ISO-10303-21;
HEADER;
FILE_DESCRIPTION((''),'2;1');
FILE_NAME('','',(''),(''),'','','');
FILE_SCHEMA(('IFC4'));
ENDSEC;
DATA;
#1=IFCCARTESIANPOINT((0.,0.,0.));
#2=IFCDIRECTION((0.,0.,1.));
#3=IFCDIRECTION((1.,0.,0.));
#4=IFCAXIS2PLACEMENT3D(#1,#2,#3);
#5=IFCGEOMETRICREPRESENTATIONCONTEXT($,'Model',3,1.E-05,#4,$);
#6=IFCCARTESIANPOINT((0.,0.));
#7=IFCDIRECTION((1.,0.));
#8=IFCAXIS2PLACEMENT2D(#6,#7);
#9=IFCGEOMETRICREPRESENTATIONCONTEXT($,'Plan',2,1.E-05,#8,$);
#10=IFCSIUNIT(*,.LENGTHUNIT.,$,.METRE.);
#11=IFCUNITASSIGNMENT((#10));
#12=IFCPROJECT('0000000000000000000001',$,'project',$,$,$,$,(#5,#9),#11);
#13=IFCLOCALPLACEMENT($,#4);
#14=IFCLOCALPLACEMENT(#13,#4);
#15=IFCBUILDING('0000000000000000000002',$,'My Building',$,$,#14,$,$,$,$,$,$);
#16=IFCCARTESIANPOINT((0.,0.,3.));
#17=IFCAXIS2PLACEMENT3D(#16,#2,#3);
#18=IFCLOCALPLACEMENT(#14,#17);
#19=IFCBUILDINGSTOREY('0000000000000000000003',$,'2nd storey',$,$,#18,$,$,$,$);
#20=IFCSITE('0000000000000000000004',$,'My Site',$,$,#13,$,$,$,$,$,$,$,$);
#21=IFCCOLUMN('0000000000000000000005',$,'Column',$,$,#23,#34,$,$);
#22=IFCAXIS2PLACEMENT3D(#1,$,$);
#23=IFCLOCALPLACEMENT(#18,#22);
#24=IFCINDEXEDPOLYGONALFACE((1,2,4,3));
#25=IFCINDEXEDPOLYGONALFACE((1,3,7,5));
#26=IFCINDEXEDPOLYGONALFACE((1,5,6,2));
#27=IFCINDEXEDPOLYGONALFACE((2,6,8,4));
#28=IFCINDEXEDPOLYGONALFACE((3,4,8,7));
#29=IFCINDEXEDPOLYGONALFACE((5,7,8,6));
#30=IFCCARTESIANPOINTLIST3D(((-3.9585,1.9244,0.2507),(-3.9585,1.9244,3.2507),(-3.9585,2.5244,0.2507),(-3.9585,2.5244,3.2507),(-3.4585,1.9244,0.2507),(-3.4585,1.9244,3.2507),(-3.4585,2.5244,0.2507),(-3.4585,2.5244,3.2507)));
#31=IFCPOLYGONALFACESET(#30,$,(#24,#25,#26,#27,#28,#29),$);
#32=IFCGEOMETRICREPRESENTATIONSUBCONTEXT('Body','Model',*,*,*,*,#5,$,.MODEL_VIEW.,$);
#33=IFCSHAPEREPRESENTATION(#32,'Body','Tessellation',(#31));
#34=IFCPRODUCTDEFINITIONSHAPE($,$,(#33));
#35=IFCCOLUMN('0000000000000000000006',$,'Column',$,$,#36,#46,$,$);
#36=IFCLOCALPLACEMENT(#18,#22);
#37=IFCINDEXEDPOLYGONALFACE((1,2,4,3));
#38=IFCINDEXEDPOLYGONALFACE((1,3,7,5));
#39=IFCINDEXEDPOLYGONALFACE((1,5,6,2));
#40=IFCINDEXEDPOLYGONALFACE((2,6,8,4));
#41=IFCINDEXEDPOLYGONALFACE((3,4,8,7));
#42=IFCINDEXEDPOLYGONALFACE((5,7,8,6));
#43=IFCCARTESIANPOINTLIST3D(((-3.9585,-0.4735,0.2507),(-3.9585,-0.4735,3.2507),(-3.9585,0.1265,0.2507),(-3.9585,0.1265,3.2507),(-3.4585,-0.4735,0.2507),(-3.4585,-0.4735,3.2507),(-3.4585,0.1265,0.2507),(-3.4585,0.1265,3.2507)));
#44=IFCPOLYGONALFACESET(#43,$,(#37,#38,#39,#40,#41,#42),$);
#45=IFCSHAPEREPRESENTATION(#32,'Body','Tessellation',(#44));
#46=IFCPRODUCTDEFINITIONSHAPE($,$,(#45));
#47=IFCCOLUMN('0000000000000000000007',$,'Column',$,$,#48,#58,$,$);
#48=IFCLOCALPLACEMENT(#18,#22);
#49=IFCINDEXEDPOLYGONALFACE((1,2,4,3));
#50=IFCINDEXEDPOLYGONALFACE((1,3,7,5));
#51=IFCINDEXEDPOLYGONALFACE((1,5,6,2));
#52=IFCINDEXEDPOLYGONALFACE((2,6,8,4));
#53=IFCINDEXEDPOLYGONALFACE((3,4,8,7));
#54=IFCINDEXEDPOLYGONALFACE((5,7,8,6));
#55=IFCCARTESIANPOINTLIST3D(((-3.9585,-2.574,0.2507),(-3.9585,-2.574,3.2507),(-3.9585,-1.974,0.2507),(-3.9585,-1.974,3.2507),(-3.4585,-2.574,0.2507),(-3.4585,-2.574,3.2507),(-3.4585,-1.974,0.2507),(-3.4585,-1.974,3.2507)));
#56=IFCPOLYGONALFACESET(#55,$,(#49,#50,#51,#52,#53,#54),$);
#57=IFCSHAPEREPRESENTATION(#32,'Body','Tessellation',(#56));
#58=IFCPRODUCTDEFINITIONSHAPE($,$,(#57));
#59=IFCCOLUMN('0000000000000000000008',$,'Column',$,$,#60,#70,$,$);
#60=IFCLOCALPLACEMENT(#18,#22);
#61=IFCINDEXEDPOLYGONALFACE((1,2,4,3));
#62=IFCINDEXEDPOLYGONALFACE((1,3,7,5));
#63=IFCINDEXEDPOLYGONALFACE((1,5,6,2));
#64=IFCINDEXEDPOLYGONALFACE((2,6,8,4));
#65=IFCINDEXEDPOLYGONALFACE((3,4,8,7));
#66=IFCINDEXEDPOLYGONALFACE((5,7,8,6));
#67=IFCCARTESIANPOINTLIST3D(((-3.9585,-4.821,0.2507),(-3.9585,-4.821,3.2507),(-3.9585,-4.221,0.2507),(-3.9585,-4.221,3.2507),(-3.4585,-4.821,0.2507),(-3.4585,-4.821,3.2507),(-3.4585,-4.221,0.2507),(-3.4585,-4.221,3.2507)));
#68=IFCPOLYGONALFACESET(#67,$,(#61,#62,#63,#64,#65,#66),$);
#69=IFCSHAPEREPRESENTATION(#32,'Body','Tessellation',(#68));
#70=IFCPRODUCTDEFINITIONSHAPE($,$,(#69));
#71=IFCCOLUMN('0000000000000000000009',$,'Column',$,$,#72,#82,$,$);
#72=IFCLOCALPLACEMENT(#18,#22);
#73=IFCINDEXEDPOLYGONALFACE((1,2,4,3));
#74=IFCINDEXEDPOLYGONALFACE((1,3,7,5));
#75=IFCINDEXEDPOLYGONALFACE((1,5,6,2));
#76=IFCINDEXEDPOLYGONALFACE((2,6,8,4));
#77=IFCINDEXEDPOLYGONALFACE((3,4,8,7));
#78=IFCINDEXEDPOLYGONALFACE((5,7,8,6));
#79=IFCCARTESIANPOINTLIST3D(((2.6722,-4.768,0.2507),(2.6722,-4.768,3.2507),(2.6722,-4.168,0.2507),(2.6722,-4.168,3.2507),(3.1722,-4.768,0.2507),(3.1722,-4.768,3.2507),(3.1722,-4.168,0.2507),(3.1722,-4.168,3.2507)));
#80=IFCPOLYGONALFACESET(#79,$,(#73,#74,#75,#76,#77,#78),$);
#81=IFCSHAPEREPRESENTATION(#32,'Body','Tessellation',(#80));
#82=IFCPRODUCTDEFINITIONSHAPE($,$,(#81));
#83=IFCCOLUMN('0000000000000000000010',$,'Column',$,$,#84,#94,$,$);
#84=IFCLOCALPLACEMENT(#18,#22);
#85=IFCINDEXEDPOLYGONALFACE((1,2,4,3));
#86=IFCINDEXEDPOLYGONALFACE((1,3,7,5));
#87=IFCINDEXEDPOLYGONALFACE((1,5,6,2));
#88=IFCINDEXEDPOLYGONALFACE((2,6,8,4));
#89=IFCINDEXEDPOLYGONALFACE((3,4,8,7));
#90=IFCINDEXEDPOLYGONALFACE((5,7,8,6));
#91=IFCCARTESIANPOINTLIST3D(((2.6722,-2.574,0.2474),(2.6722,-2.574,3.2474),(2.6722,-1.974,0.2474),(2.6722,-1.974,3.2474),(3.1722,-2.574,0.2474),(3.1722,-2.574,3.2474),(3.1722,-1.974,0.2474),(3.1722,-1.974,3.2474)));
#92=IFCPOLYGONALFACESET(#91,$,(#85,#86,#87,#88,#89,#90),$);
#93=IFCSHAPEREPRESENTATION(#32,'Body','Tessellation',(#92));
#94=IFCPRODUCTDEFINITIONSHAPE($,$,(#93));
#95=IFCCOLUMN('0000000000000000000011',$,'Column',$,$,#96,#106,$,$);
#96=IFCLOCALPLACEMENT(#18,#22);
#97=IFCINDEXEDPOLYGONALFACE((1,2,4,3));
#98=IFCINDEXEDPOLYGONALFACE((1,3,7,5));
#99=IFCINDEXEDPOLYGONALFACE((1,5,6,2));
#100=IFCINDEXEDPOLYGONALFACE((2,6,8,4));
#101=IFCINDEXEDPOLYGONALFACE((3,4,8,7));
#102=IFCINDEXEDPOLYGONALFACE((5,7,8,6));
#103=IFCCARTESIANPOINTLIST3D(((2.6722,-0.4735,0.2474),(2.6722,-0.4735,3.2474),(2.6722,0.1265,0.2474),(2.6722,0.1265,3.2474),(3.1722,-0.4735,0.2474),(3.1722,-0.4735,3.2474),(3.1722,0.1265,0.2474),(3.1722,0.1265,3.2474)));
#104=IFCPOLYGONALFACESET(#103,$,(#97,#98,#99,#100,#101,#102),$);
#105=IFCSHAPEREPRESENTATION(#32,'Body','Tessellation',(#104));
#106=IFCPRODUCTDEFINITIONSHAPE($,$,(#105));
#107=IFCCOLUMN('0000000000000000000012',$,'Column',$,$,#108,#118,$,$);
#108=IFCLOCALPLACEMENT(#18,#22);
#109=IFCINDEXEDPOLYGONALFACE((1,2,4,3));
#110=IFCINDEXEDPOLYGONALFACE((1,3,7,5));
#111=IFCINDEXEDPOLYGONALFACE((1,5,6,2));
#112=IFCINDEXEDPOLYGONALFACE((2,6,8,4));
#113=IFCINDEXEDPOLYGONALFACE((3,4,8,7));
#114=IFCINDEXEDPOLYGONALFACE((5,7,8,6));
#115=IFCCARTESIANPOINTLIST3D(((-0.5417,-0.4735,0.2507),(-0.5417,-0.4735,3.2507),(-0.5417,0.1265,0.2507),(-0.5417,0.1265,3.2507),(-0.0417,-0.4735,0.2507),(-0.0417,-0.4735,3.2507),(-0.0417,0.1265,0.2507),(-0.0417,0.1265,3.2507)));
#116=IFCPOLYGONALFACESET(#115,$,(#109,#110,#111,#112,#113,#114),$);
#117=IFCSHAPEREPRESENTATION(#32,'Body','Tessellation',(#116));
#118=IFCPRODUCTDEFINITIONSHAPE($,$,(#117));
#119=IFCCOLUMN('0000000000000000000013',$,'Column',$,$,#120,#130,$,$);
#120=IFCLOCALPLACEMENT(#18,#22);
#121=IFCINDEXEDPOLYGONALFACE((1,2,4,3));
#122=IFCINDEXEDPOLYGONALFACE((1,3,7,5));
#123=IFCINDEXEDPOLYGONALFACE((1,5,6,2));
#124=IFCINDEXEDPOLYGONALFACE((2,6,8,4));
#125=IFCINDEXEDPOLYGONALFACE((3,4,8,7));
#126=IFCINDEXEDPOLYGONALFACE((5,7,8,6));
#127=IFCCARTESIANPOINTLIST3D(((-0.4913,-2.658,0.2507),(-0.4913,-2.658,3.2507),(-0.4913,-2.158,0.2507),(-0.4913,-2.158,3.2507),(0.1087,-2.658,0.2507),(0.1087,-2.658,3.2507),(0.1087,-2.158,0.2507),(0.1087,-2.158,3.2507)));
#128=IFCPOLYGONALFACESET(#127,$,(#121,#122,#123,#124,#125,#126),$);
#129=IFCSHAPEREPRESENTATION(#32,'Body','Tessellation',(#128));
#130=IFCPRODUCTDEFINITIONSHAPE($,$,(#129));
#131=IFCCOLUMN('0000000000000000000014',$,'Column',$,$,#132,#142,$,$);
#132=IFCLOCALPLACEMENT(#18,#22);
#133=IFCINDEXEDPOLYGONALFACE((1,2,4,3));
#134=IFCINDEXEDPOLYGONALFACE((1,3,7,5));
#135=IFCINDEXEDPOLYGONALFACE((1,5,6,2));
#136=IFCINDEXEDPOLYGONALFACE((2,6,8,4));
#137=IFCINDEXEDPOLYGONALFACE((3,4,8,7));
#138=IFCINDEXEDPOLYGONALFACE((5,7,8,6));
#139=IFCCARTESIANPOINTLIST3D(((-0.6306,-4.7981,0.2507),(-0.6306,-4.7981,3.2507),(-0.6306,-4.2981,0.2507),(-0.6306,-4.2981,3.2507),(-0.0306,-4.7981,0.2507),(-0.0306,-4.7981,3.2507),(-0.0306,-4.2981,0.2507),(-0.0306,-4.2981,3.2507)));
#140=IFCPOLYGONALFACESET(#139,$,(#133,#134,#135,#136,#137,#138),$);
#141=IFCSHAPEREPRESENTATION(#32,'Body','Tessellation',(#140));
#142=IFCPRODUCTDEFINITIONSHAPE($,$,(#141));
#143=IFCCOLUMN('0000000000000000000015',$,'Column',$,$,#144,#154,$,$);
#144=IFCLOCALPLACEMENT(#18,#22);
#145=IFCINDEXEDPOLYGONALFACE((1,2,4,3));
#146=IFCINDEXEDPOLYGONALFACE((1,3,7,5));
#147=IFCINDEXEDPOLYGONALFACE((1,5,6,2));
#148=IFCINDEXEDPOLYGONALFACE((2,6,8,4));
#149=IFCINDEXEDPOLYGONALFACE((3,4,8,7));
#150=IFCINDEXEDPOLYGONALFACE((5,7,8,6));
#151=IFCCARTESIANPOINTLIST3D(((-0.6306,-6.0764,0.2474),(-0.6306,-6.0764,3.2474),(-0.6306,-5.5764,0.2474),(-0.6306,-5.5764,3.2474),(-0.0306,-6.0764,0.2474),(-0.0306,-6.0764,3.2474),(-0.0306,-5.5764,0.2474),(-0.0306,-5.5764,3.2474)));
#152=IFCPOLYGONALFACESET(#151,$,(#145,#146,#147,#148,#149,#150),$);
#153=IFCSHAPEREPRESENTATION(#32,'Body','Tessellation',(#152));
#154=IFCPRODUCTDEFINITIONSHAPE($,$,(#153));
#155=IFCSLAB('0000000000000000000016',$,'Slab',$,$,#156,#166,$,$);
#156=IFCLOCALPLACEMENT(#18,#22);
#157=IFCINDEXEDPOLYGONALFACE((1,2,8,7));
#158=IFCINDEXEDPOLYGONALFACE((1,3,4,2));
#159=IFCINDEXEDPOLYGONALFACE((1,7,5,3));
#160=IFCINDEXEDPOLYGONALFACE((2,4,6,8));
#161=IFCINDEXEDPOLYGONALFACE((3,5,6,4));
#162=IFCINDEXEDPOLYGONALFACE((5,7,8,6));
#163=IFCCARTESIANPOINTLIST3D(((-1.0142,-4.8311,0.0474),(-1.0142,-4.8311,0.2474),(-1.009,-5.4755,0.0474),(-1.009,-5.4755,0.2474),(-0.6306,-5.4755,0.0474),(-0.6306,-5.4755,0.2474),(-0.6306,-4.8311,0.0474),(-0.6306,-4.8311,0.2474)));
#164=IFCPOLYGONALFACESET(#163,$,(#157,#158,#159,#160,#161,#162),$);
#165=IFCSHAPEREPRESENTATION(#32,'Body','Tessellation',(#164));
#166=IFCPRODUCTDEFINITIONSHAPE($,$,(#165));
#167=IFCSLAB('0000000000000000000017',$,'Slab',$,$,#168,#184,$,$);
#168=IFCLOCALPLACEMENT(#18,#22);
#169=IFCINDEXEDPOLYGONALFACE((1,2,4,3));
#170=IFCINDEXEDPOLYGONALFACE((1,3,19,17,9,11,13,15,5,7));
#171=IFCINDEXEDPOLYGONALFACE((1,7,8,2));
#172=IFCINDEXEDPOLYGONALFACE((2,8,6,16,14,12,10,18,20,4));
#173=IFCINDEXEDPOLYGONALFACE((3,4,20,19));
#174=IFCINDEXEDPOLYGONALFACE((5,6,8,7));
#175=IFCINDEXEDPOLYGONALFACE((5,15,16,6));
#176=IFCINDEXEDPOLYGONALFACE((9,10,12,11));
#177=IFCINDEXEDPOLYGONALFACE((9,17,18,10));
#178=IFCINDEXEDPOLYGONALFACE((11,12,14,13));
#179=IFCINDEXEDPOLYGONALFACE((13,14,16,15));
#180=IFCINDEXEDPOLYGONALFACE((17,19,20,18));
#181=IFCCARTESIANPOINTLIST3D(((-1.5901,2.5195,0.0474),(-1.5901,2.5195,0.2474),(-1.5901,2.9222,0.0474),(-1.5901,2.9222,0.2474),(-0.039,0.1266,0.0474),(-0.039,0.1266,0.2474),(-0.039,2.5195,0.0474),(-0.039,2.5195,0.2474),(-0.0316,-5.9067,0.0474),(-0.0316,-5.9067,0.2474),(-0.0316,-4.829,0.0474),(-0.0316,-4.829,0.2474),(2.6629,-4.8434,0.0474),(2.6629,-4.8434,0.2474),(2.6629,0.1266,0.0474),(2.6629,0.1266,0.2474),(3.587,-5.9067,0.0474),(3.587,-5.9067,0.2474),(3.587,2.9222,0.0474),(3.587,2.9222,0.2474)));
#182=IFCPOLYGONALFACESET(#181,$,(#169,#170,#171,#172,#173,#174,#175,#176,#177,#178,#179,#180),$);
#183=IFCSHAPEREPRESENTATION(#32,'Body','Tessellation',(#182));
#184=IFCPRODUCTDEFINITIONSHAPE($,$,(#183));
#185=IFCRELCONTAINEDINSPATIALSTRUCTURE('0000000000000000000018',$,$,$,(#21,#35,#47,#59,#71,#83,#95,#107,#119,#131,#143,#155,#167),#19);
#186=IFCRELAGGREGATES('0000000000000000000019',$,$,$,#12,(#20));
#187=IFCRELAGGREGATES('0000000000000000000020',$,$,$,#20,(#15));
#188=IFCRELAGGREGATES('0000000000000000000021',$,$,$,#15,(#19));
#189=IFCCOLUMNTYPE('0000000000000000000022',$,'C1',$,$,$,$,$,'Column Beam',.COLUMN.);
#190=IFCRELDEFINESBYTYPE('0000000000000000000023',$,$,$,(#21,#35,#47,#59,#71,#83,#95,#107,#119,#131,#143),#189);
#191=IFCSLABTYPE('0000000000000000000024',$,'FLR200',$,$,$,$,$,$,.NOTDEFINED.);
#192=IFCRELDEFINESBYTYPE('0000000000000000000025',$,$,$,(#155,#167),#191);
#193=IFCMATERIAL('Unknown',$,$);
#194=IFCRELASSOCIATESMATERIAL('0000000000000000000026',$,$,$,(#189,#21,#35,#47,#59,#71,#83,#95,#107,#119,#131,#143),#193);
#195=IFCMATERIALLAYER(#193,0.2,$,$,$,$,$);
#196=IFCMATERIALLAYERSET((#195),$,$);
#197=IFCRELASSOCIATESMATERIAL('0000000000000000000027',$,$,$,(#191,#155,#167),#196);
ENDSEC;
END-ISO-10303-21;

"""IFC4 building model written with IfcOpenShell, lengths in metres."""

from ifc_helpers import new_model, si_unit, frame, origin_with_axes, origin_2d_with_axis, place, context, subcontext, project, spatial, indexed_curve, outline, extrude, material, layer, layer_set, layer_usage, material_profile, profile_set, profile_usage, type_object, element, save


model = new_model("IFC4")

# Units and contexts
model_context = context("Model", 3, precision=1e-05, world=origin_with_axes())
plan_context = context("Plan", 2, precision=1e-05, world=origin_2d_with_axis())
body_context = subcontext(model_context, "Body", "Model", "MODEL_VIEW")
ifc_project = project(units=[si_unit("LENGTHUNIT", "METRE")], contexts=[model_context, plan_context])

# Site, building, storey
site_placement = place(None, origin_with_axes())
site = spatial("IfcSite", under=ifc_project, at=site_placement, Name="My Site")
building_placement = place(site_placement, origin_with_axes())
building = spatial("IfcBuilding", under=site, at=building_placement, Name="My Building")
storey_placement = place(building_placement, frame((0.0, 0.0, 3.0), z_axis=(0.0, 0.0, 1.0), x_axis=(1.0, 0.0, 0.0)))
storey = spatial("IfcBuildingStorey", under=building, at=storey_placement, Name="2nd storey")

# Columns
ifc_material = material(Name="Unknown")
ifc_material_profile = material_profile(ifc_material, outline(indexed_curve([(-0.25, -0.3), (0.25, -0.3), (0.25, 0.3), (-0.25, 0.3), (-0.25, -0.3)])))
ifc_profile_set = profile_set([ifc_material_profile])
ifc_profile_usage_1 = profile_usage(ifc_profile_set, cardinal=5)
column_type = type_object("IfcColumnType", Name="C1", ElementType="Column Beam", PredefinedType="COLUMN", material=ifc_profile_set)
column_1_placement = place(storey_placement, frame((-3.7085, 2.2244, 0.2507), z_axis=(0.0, 0.0, 1.0), x_axis=(1.0, 0.0, 0.0)))
element("IfcColumn", 1, at=column_1_placement, inside=storey, type_object=column_type, material=ifc_profile_usage_1, Name="Column", context=body_context, shape_type="SweptSolid", body=[
    extrude(outline(indexed_curve([(-0.25, -0.3), (0.25, -0.3), (0.25, 0.3), (-0.25, 0.3), (-0.25, -0.3)])), origin_with_axes(), (0.0, 0.0, 1.0), 3.0),
])
ifc_profile_usage_2 = profile_usage(ifc_profile_set, cardinal=5)
column_2_placement = place(storey_placement, frame((-3.7085, -0.1735, 0.2507), z_axis=(0.0, 0.0, 1.0), x_axis=(1.0, 0.0, 0.0)))
element("IfcColumn", 2, at=column_2_placement, inside=storey, type_object=column_type, material=ifc_profile_usage_2, Name="Column", context=body_context, shape_type="SweptSolid", body=[
    extrude(outline(indexed_curve([(-0.25, -0.3), (0.25, -0.3), (0.25, 0.3), (-0.25, 0.3), (-0.25, -0.3)])), origin_with_axes(), (0.0, 0.0, 1.0), 3.0),
])
ifc_profile_usage_3 = profile_usage(ifc_profile_set, cardinal=5)
column_3_placement = place(storey_placement, frame((-3.7085, -2.274, 0.2507), z_axis=(0.0, 0.0, 1.0), x_axis=(1.0, 0.0, 0.0)))
element("IfcColumn", 3, at=column_3_placement, inside=storey, type_object=column_type, material=ifc_profile_usage_3, Name="Column", context=body_context, shape_type="SweptSolid", body=[
    extrude(outline(indexed_curve([(-0.25, -0.3), (0.25, -0.3), (0.25, 0.3), (-0.25, 0.3), (-0.25, -0.3)])), origin_with_axes(), (0.0, 0.0, 1.0), 3.0),
])
ifc_profile_usage_4 = profile_usage(ifc_profile_set, cardinal=5)
column_4_placement = place(storey_placement, frame((-3.7085, -4.521, 0.2507), z_axis=(0.0, 0.0, 1.0), x_axis=(1.0, 0.0, 0.0)))
element("IfcColumn", 4, at=column_4_placement, inside=storey, type_object=column_type, material=ifc_profile_usage_4, Name="Column", context=body_context, shape_type="SweptSolid", body=[
    extrude(outline(indexed_curve([(-0.25, -0.3), (0.25, -0.3), (0.25, 0.3), (-0.25, 0.3), (-0.25, -0.3)])), origin_with_axes(), (0.0, 0.0, 1.0), 3.0),
])
ifc_profile_usage_5 = profile_usage(ifc_profile_set, cardinal=5)
column_5_placement = place(storey_placement, frame((2.9222, -4.468, 0.2507), z_axis=(0.0, 0.0, 1.0), x_axis=(1.0, 0.0, 0.0)))
element("IfcColumn", 5, at=column_5_placement, inside=storey, type_object=column_type, material=ifc_profile_usage_5, Name="Column", context=body_context, shape_type="SweptSolid", body=[
    extrude(outline(indexed_curve([(-0.25, -0.3), (0.25, -0.3), (0.25, 0.3), (-0.25, 0.3), (-0.25, -0.3)])), origin_with_axes(), (0.0, 0.0, 1.0), 3.0),
])
ifc_profile_usage_6 = profile_usage(ifc_profile_set, cardinal=5)
column_6_placement = place(storey_placement, frame((2.9222, -2.274, 0.2474), z_axis=(0.0, 0.0, 1.0), x_axis=(1.0, 0.0, 0.0)))
element("IfcColumn", 6, at=column_6_placement, inside=storey, type_object=column_type, material=ifc_profile_usage_6, Name="Column", context=body_context, shape_type="SweptSolid", body=[
    extrude(outline(indexed_curve([(-0.25, -0.3), (0.25, -0.3), (0.25, 0.3), (-0.25, 0.3), (-0.25, -0.3)])), origin_with_axes(), (0.0, 0.0, 1.0), 3.0),
])
ifc_profile_usage_7 = profile_usage(ifc_profile_set, cardinal=5)
column_7_placement = place(storey_placement, frame((2.9222, -0.1735, 0.2474), z_axis=(0.0, 0.0, 1.0), x_axis=(1.0, 0.0, 0.0)))
element("IfcColumn", 7, at=column_7_placement, inside=storey, type_object=column_type, material=ifc_profile_usage_7, Name="Column", context=body_context, shape_type="SweptSolid", body=[
    extrude(outline(indexed_curve([(-0.25, -0.3), (0.25, -0.3), (0.25, 0.3), (-0.25, 0.3), (-0.25, -0.3)])), origin_with_axes(), (0.0, 0.0, 1.0), 3.0),
])
ifc_profile_usage_8 = profile_usage(ifc_profile_set, cardinal=5)
column_8_placement = place(storey_placement, frame((-0.2917, -0.1735, 0.2507), z_axis=(0.0, 0.0, 1.0), x_axis=(1.0, 0.0, 0.0)))
element("IfcColumn", 8, at=column_8_placement, inside=storey, type_object=column_type, material=ifc_profile_usage_8, Name="Column", context=body_context, shape_type="SweptSolid", body=[
    extrude(outline(indexed_curve([(-0.25, -0.3), (0.25, -0.3), (0.25, 0.3), (-0.25, 0.3), (-0.25, -0.3)])), origin_with_axes(), (0.0, 0.0, 1.0), 3.0),
])
ifc_profile_usage_9 = profile_usage(ifc_profile_set, cardinal=5)
column_9_placement = place(storey_placement, frame((-0.1913, -2.408, 0.2507), z_axis=(0.0, 0.0, 1.0), x_axis=(0.0, -1.0, 0.0)))
element("IfcColumn", 9, at=column_9_placement, inside=storey, type_object=column_type, material=ifc_profile_usage_9, Name="Column", context=body_context, shape_type="SweptSolid", body=[
    extrude(outline(indexed_curve([(-0.25, -0.3), (0.25, -0.3), (0.25, 0.3), (-0.25, 0.3), (-0.25, -0.3)])), origin_with_axes(), (0.0, 0.0, 1.0), 3.0),
])
ifc_profile_usage_10 = profile_usage(ifc_profile_set, cardinal=5)
column_10_placement = place(storey_placement, frame((-0.3306, -4.5481, 0.2507), z_axis=(0.0, 0.0, 1.0), x_axis=(0.0, -1.0, 0.0)))
element("IfcColumn", 10, at=column_10_placement, inside=storey, type_object=column_type, material=ifc_profile_usage_10, Name="Column", context=body_context, shape_type="SweptSolid", body=[
    extrude(outline(indexed_curve([(-0.25, -0.3), (0.25, -0.3), (0.25, 0.3), (-0.25, 0.3), (-0.25, -0.3)])), origin_with_axes(), (0.0, 0.0, 1.0), 3.0),
])
ifc_profile_usage_11 = profile_usage(ifc_profile_set, cardinal=5)
column_11_placement = place(storey_placement, frame((-0.3306, -5.8264, 0.2474), z_axis=(0.0, 0.0, 1.0), x_axis=(0.0, -1.0, 0.0)))
element("IfcColumn", 11, at=column_11_placement, inside=storey, type_object=column_type, material=ifc_profile_usage_11, Name="Column", context=body_context, shape_type="SweptSolid", body=[
    extrude(outline(indexed_curve([(-0.25, -0.3), (0.25, -0.3), (0.25, 0.3), (-0.25, 0.3), (-0.25, -0.3)])), origin_with_axes(), (0.0, 0.0, 1.0), 3.0),
])

# Slabs
ifc_layer_1 = layer(ifc_material, 0.2)
ifc_layer_set_1 = layer_set([ifc_layer_1])
ifc_layer_usage_1 = layer_usage(ifc_layer_set_1, "AXIS3", "POSITIVE", -0.2)
slab_type_1 = type_object("IfcSlabType", Name="FLR200", PredefinedType="NOTDEFINED", material=ifc_layer_set_1)
slab_1_placement = place(storey_placement, frame((-1.0142, -4.8311, 0.2474), z_axis=(0.0, 0.0, 1.0), x_axis=(1.0, 0.0, 0.0)))
element("IfcSlab", 12, at=slab_1_placement, inside=storey, type_object=slab_type_1, material=ifc_layer_usage_1, Name="Slab", context=body_context, shape_type="SweptSolid", body=[
    extrude(outline(indexed_curve([(0.0, 0.0), (0.3836, 0.0), (0.3836, -0.6445), (0.0052, -0.6445), (0.0, 0.0)])), frame((0.0, 0.0, -0.2), z_axis=(0.0, 0.0, 1.0), x_axis=(1.0, 0.0, 0.0)), (0.0, 0.0, 1.0), 0.2),
])
ifc_layer_usage_2 = layer_usage(ifc_layer_set_1, "AXIS3", "POSITIVE", -0.2)
slab_2_placement = place(storey_placement, frame((-0.0316, -4.829, 0.2474), z_axis=(0.0, 0.0, 1.0), x_axis=(1.0, 0.0, 0.0)))
element("IfcSlab", 13, at=slab_2_placement, inside=storey, type_object=slab_type_1, material=ifc_layer_usage_2, Name="Slab", context=body_context, shape_type="SweptSolid", body=[
    extrude(outline(indexed_curve([(0.0, 0.0), (0.0, -1.0776), (3.6186, -1.0776), (3.6186, 7.7512), (-1.5585, 7.7512), (-1.5585, 7.3485), (-0.0074, 7.3485), (-0.0074, 4.9556), (2.6945, 4.9556), (2.6945, -0.0144), (0.0, 0.0)])), frame((0.0, 0.0, -0.2), z_axis=(0.0, 0.0, 1.0), x_axis=(1.0, 0.0, 0.0)), (0.0, 0.0, 1.0), 0.2),
])

save(model, "model.ifc")
